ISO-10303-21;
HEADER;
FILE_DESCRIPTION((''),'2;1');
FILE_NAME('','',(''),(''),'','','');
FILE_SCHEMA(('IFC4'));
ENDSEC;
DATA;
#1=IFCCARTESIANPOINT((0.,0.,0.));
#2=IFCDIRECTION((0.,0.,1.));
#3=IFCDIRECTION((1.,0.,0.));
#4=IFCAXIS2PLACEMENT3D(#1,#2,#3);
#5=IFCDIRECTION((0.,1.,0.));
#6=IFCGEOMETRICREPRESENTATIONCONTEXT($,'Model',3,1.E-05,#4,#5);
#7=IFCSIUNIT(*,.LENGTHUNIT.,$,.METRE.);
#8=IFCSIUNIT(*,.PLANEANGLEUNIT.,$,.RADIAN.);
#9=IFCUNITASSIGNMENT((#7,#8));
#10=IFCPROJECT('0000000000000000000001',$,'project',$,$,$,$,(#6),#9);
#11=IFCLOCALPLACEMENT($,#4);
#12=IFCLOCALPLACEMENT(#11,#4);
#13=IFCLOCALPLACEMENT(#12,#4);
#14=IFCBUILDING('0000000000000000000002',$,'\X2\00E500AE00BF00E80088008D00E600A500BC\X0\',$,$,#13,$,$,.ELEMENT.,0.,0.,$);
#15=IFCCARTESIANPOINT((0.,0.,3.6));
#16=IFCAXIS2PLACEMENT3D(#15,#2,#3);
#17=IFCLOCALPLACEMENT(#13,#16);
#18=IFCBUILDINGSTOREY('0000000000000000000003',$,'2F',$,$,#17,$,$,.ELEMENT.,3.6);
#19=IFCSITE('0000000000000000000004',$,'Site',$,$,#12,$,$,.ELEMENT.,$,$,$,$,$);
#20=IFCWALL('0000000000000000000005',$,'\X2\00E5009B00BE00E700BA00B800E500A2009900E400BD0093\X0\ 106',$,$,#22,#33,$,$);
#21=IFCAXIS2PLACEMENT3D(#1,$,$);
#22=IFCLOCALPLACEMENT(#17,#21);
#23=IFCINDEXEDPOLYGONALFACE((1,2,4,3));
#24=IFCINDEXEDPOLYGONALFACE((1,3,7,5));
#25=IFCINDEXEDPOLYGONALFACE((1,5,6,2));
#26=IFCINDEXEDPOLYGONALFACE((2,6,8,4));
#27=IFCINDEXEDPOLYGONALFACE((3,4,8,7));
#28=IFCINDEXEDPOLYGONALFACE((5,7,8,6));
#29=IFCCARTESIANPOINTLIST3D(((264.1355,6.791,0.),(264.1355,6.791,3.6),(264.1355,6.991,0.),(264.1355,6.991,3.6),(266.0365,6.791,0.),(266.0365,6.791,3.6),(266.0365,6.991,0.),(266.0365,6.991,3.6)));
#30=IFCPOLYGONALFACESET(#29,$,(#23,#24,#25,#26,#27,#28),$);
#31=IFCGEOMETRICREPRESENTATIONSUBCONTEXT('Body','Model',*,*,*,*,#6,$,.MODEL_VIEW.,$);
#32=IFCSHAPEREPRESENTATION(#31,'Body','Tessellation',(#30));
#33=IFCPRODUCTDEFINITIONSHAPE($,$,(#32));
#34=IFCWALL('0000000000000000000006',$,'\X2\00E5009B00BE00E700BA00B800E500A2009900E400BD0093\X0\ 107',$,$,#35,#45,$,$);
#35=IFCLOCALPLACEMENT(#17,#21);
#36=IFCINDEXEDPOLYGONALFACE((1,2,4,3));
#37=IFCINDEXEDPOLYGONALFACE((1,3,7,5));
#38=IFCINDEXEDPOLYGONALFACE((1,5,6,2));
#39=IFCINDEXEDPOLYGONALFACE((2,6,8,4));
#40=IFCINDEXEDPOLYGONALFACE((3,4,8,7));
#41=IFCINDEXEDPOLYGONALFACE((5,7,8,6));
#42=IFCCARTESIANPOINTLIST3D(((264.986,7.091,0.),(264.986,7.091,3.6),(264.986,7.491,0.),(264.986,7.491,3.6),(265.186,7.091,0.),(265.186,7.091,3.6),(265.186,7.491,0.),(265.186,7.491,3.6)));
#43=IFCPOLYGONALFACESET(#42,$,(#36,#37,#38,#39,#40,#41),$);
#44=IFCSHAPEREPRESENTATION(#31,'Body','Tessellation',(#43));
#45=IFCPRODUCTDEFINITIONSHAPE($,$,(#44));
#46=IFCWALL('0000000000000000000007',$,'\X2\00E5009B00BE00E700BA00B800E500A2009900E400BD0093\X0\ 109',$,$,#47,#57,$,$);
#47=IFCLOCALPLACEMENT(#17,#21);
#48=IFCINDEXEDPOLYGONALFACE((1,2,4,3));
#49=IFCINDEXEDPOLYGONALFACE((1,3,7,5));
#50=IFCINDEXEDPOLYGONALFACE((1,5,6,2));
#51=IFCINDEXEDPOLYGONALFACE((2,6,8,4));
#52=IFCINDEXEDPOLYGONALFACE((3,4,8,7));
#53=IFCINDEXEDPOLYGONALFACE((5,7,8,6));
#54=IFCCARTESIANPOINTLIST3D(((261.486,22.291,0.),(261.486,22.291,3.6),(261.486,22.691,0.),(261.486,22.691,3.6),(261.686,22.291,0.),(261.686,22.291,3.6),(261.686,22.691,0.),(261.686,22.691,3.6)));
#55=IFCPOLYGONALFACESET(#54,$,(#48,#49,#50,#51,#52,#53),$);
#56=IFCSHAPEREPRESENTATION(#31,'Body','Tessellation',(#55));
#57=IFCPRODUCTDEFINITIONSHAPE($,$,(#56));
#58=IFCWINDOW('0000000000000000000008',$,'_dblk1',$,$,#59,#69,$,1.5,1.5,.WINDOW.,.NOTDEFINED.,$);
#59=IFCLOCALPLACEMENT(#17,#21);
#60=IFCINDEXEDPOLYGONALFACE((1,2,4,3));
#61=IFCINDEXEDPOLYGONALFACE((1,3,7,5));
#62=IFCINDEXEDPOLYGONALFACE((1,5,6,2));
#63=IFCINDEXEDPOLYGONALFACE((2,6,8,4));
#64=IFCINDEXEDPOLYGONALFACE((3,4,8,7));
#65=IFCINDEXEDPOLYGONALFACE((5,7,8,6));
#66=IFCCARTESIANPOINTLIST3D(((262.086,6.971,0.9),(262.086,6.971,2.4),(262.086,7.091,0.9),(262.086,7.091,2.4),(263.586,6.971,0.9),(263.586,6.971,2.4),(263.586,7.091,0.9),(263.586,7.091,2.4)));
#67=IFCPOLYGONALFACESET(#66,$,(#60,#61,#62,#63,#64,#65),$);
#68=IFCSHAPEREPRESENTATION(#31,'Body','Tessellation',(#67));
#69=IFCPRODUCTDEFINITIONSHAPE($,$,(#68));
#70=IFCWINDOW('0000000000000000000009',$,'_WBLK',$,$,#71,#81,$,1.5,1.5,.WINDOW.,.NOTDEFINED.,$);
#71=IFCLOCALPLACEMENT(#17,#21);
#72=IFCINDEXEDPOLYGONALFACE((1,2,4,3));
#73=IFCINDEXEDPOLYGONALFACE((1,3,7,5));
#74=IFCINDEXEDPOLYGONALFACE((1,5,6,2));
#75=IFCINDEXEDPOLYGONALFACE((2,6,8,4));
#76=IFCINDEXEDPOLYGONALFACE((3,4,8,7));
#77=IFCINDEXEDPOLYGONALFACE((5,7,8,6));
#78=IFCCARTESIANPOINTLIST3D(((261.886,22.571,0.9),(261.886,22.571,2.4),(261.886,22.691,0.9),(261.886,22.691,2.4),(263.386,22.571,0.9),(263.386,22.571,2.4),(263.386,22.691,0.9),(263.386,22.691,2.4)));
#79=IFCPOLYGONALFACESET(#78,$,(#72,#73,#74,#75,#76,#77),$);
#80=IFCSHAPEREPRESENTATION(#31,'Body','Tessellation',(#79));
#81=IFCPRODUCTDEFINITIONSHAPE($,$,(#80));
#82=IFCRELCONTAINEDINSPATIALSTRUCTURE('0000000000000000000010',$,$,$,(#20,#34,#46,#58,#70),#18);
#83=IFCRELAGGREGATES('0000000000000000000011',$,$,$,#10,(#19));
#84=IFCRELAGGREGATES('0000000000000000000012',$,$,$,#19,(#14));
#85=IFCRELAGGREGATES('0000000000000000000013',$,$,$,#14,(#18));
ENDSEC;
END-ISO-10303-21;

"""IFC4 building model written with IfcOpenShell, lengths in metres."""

from ifc_helpers import new_model, si_unit, direction, frame, frame_2d, origin_with_axes, place, context, subcontext, project, spatial, rectangle, extrude, element, save


model = new_model("IFC4")

# Units and contexts
model_context = context("Model", 3, precision=1e-05, world=origin_with_axes(), true_north=direction((0.0, 1.0, 0.0)))
body_context = subcontext(model_context, "Body", "Model", "MODEL_VIEW")
ifc_project = project(units=[si_unit("LENGTHUNIT", "METRE"), si_unit("PLANEANGLEUNIT", "RADIAN")], contexts=[model_context])

# Site, building, storey
placement = place(None, origin_with_axes())
site_placement = place(placement, origin_with_axes())
site = spatial("IfcSite", under=ifc_project, at=site_placement, Name="Site", CompositionType="ELEMENT")
building_placement = place(site_placement, origin_with_axes())
building = spatial("IfcBuilding", under=site, at=building_placement, Name="å®¿è\u0088\u008dæ¥¼", CompositionType="ELEMENT", ElevationOfRefHeight=0.0, ElevationOfTerrain=0.0)
storey_placement = place(building_placement, frame((0.0, 0.0, 3.6), z_axis=(0.0, 0.0, 1.0), x_axis=(1.0, 0.0, 0.0)))
storey = spatial("IfcBuildingStorey", under=building, at=storey_placement, Name="2F", CompositionType="ELEMENT", Elevation=3.6)

# Walls
wall_1_placement = place(storey_placement, frame((265.086, 6.891, 0.0), z_axis=(0.0, 0.0, 1.0), x_axis=(1.0, 0.0, 0.0)))
element("IfcWall", 1, at=wall_1_placement, inside=storey, Name="å\u009b¾çº¸å¢\u0099ä½\u0093 106", context=body_context, shape_type="SweptSolid", body=[
    extrude(rectangle(XDim=1.901, YDim=0.2, at=frame_2d((0.0, 0.0), x_axis=(1.0, 0.0, 0.0))), frame((0.0, 0.0, 0.0), z_axis=(0.0, 0.0, 1.0)), (0.0, 0.0, 1.0), 3.6),
])
for number, where, z_axis, x_axis, name in (
    (2, (265.086, 7.291, 0.0), (0.0, 0.0, 1.0), (0.0, -1.0, 0.0), "å\u009b¾çº¸å¢\u0099ä½\u0093 107"),
    (3, (261.586, 22.491, 0.0), (0.0, 0.0, 1.0), (0.0, 1.0, 0.0), "å\u009b¾çº¸å¢\u0099ä½\u0093 109"),
):
    element("IfcWall", number, at=place(storey_placement, frame(where, z_axis=z_axis, x_axis=x_axis)), inside=storey, Name=name, context=body_context, shape_type="SweptSolid", body=[
        extrude(rectangle(XDim=0.4, YDim=0.2, at=frame_2d((0.0, 0.0), x_axis=(1.0, 0.0, 0.0))), frame((0.0, 0.0, 0.0), z_axis=(0.0, 0.0, 1.0)), (0.0, 0.0, 1.0), 3.6),
    ])

# Windows
for number, where, z_axis, x_axis, name in (
    (4, (262.836, 7.031, 0.9), (0.0, 0.0, 1.0), (1.0, 0.0, 0.0), "_dblk1"),
    (5, (262.636, 22.631, 0.9), (0.0, 0.0, 1.0), (1.0, 0.0, 0.0), "_WBLK"),
):
    element("IfcWindow", number, at=place(storey_placement, frame(where, z_axis=z_axis, x_axis=x_axis)), inside=storey, Name=name, OverallHeight=1.5, OverallWidth=1.5, PartitioningType="NOTDEFINED", PredefinedType="WINDOW", context=body_context, shape_type="SweptSolid", body=[
        extrude(rectangle(XDim=1.5, YDim=0.12, at=frame_2d((0.0, 0.0), x_axis=(1.0, 0.0, 0.0))), frame((0.0, 0.0, 0.0), z_axis=(0.0, 0.0, 1.0)), (0.0, 0.0, 1.0), 1.5),
    ])

save(model, "model.ifc")
